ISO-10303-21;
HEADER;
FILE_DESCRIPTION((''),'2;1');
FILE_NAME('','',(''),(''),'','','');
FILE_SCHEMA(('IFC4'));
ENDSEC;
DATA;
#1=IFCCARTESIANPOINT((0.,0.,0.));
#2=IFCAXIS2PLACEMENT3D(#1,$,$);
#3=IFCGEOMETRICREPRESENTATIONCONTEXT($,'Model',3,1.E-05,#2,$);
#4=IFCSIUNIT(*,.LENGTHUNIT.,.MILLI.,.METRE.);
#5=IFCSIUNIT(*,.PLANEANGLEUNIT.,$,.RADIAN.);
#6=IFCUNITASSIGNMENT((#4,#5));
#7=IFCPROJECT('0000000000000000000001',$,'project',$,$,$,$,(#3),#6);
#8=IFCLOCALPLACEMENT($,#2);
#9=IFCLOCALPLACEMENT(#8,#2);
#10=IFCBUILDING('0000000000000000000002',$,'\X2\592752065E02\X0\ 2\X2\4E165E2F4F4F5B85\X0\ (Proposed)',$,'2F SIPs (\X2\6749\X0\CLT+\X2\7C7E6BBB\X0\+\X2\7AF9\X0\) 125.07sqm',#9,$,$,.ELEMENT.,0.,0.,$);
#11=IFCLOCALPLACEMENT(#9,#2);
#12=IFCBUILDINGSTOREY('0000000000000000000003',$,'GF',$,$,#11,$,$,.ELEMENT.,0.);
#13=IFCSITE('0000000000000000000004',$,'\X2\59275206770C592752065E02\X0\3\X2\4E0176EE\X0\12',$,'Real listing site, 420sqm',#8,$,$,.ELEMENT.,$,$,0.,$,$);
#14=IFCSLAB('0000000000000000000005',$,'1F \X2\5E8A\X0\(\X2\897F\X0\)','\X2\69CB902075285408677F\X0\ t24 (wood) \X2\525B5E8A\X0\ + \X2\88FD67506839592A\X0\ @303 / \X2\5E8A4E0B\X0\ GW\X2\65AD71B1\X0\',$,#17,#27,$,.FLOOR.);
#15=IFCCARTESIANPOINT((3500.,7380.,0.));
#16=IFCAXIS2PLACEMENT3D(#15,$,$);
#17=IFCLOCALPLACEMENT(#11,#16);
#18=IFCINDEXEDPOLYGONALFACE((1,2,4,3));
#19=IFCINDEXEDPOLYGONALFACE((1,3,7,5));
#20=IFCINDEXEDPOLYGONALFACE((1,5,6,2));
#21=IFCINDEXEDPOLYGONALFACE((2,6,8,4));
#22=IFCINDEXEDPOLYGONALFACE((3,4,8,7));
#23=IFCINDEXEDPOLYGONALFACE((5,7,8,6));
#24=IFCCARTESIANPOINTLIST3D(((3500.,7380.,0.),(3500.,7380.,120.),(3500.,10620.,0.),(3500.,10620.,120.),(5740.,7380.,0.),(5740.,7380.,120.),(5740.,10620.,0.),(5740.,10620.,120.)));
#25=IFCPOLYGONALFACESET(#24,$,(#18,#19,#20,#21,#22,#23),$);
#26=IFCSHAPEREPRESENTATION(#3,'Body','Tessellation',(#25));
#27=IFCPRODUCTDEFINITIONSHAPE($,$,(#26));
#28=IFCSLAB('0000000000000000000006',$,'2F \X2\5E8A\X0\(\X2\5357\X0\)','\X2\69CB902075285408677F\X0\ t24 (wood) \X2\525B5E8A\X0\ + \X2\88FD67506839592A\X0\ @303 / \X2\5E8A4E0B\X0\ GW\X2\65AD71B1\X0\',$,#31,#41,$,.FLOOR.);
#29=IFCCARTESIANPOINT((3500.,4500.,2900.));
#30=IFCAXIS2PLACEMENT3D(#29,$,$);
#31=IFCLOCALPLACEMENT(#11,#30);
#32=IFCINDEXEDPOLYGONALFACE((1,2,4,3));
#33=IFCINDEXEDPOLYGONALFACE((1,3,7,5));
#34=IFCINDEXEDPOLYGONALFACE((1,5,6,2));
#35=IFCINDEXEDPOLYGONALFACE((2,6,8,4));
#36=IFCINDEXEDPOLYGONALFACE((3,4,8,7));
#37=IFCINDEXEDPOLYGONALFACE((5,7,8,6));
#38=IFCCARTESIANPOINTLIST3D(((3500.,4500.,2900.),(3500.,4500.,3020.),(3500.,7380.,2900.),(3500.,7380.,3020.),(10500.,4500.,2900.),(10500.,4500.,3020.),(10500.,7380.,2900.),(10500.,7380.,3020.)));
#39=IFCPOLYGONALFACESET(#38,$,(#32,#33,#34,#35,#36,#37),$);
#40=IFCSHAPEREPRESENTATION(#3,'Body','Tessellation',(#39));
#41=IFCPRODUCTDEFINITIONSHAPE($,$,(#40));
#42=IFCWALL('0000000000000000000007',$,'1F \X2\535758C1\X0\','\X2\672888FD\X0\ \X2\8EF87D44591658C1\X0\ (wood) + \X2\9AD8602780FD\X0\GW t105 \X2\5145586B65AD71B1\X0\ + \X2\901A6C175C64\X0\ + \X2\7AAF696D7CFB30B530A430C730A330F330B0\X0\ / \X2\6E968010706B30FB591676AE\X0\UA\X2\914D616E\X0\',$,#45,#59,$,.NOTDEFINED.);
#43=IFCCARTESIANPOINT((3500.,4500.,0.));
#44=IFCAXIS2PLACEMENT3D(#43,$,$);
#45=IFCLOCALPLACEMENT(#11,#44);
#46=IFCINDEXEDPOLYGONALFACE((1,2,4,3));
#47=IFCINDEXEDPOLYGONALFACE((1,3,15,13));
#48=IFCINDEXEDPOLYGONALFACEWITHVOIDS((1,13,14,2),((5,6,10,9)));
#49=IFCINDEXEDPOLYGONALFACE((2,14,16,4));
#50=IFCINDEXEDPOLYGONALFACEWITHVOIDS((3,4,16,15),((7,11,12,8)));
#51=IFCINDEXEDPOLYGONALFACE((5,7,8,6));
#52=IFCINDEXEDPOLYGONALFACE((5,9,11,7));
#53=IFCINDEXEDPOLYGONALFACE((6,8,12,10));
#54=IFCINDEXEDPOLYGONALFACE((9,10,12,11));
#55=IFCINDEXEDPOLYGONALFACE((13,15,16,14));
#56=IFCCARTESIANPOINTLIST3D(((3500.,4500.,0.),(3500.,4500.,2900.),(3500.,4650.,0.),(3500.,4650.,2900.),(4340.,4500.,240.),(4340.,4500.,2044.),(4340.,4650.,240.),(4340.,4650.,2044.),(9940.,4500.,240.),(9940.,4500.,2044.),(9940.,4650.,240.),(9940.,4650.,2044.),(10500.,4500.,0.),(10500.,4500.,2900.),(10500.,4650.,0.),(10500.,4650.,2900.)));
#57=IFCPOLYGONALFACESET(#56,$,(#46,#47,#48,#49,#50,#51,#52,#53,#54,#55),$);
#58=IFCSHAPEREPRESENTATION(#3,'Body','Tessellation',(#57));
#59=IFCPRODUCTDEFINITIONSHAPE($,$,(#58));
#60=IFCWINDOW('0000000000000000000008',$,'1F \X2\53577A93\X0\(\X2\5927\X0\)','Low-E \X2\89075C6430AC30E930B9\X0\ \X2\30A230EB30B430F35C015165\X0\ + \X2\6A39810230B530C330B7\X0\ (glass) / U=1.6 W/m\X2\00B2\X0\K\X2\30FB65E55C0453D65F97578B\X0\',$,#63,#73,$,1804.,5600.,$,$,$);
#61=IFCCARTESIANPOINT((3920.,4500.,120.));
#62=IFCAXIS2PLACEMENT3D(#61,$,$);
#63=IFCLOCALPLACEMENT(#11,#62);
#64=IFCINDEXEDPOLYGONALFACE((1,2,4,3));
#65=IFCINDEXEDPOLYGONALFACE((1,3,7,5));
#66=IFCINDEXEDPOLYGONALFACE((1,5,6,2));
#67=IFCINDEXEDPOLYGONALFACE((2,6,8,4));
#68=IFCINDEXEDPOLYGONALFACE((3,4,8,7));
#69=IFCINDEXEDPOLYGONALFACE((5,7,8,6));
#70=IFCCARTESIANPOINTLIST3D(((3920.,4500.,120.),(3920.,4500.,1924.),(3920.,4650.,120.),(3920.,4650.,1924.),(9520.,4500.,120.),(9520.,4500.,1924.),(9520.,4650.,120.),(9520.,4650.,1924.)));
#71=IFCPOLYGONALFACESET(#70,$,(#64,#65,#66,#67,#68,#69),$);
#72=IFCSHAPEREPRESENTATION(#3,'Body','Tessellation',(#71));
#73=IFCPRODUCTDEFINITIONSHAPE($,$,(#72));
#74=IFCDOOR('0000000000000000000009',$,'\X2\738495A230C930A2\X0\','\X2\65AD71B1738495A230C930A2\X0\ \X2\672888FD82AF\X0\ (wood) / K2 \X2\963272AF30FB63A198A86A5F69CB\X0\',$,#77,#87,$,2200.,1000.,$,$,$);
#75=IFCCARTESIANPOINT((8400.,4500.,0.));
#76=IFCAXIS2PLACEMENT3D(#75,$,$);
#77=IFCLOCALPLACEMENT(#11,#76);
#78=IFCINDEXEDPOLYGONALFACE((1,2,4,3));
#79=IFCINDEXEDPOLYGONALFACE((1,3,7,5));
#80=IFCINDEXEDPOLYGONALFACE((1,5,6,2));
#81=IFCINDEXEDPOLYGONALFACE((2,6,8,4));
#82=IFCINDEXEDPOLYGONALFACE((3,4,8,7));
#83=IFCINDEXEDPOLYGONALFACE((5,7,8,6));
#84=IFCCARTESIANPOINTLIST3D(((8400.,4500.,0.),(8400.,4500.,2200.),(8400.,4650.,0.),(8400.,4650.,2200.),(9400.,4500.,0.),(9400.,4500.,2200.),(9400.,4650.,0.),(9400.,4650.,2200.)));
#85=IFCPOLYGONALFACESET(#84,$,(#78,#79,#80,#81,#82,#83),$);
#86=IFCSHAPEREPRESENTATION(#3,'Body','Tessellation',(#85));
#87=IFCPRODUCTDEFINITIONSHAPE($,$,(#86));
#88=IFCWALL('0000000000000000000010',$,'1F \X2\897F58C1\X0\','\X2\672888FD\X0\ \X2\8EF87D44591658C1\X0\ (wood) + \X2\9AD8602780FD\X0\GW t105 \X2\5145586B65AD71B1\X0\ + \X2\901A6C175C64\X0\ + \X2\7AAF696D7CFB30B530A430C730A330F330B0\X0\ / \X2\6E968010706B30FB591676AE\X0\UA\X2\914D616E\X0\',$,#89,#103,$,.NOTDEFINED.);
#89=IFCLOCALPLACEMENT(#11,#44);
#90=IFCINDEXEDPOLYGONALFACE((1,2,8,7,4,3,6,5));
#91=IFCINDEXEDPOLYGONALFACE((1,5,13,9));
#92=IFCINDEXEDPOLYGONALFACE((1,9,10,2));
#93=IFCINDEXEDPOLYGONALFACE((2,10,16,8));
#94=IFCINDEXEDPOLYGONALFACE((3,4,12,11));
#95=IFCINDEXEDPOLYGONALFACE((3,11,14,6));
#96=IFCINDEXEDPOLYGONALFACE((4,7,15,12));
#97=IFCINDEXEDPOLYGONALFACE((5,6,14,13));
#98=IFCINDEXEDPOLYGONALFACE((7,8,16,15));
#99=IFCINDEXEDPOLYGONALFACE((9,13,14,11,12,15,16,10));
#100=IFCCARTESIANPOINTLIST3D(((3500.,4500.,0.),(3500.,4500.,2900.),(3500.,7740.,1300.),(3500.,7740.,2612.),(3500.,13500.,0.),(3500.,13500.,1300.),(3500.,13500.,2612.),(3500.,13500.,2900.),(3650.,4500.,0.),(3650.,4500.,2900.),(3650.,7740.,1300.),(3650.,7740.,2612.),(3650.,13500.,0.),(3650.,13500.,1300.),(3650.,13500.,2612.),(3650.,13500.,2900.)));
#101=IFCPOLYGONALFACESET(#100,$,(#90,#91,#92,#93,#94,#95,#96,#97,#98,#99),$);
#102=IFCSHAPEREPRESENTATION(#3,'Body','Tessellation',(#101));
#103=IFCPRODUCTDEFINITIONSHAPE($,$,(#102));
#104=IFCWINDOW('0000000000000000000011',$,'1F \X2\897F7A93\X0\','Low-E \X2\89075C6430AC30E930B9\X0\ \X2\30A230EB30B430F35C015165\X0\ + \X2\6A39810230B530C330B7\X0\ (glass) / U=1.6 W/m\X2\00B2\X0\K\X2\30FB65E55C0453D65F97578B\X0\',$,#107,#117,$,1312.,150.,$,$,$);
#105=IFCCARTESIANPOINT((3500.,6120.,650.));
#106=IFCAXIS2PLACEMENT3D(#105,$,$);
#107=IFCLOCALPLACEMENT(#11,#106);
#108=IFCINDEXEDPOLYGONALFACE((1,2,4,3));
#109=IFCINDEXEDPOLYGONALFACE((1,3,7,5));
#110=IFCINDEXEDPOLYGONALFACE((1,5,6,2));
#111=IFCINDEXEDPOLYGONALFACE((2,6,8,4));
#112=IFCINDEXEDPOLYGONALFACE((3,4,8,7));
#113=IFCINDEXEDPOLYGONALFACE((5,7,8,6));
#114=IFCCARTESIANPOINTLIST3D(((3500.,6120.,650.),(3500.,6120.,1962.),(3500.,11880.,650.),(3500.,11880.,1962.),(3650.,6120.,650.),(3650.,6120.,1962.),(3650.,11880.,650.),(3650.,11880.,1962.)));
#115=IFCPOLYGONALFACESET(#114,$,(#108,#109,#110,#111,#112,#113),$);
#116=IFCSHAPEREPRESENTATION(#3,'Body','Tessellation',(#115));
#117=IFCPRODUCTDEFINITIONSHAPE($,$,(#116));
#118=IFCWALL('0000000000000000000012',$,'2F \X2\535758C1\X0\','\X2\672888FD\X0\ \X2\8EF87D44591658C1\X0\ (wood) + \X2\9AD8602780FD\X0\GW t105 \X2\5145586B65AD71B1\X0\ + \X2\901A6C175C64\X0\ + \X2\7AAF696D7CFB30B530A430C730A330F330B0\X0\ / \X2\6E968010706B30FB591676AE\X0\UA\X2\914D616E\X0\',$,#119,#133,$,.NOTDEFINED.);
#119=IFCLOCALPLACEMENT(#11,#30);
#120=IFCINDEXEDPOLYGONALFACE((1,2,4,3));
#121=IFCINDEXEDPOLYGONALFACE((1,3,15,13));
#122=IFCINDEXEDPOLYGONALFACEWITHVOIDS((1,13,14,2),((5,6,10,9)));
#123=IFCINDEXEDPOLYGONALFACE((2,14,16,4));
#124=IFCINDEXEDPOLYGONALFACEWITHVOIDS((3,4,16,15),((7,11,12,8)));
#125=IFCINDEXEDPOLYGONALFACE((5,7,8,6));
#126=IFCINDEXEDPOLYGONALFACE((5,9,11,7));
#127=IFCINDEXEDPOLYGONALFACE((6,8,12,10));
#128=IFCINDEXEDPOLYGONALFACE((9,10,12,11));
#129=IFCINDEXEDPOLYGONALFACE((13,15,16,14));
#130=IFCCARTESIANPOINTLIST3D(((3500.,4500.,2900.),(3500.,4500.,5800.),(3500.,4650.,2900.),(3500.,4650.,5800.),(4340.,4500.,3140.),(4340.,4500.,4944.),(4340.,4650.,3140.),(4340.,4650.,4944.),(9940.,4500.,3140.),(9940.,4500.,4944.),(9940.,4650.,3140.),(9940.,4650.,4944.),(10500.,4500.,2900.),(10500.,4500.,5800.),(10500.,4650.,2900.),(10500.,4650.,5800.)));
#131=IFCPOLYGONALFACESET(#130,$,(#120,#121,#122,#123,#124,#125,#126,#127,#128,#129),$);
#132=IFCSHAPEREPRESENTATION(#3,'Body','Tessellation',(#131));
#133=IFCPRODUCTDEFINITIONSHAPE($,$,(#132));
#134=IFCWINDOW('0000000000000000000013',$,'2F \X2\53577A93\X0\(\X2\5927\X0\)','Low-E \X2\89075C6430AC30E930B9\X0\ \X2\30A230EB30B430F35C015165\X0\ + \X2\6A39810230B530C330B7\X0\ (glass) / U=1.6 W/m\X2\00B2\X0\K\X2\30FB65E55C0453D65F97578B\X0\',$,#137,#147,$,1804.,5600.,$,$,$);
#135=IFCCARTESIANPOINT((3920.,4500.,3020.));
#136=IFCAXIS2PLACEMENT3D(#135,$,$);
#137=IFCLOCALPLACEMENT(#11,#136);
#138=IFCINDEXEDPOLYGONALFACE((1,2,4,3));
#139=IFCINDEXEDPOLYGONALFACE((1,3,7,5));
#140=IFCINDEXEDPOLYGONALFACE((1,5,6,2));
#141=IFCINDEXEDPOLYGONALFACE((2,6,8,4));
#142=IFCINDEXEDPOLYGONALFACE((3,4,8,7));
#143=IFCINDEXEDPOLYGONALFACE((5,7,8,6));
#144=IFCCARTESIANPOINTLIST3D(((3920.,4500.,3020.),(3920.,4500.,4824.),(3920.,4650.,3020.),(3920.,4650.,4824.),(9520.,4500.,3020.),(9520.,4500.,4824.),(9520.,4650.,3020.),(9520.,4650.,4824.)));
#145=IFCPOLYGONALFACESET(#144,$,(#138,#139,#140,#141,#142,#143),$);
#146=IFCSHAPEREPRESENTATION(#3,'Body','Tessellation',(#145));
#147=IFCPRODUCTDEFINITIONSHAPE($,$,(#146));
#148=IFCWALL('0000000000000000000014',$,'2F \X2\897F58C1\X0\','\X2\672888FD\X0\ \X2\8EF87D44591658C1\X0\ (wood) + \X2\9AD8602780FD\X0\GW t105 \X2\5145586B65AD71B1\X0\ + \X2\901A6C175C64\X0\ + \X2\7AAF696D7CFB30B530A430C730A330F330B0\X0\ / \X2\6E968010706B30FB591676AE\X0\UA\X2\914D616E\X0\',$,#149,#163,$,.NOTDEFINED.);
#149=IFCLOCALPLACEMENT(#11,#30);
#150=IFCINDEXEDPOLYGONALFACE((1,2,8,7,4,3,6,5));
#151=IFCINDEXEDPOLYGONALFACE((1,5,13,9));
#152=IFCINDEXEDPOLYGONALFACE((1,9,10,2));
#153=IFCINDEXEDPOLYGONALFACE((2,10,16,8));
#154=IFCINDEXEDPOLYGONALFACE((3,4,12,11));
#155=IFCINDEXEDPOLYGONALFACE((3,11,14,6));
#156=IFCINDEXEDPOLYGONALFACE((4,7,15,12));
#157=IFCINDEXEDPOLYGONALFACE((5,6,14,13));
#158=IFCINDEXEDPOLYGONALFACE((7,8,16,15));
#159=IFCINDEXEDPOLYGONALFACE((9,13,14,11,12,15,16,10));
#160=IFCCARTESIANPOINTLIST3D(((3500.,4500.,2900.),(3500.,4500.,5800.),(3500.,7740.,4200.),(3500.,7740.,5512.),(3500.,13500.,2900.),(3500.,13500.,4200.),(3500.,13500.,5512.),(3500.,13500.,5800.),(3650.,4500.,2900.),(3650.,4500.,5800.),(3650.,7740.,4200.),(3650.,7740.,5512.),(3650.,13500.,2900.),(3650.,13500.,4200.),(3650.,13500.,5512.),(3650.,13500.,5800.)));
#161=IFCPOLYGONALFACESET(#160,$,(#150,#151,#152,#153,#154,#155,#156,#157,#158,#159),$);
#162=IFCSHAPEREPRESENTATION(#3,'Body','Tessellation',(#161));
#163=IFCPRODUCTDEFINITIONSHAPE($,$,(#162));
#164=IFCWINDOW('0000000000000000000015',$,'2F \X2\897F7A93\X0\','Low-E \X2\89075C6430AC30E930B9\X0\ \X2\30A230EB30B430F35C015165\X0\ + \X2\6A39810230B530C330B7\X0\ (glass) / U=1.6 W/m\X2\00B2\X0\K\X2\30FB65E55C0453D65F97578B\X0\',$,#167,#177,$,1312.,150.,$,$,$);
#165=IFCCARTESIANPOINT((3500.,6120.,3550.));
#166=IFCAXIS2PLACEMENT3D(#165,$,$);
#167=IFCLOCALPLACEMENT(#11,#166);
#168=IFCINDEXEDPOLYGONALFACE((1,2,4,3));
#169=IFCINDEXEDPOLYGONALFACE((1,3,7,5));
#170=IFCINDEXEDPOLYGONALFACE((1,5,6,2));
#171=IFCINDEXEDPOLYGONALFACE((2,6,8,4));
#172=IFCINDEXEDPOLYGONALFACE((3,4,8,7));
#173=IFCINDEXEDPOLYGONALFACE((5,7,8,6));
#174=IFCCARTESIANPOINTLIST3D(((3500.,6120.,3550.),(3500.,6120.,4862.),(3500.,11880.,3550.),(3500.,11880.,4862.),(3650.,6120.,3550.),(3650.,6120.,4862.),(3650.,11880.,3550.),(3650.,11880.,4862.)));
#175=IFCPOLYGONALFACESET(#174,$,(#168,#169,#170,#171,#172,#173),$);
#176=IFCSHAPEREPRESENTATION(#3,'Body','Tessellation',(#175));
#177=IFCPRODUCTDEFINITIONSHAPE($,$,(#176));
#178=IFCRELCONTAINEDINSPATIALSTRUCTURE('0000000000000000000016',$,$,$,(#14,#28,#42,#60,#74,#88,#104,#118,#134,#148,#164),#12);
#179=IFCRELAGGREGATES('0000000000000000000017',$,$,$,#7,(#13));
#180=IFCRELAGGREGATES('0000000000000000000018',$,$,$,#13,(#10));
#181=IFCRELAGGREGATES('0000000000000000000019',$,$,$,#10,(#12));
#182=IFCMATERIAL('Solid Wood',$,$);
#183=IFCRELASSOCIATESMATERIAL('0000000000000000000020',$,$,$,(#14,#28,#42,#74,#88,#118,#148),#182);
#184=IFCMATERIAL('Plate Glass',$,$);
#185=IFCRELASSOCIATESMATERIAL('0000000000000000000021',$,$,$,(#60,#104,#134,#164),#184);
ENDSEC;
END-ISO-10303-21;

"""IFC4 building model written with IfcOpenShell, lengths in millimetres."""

from ifc_helpers import new_model, si_unit, frame, frame_2d, origin, place, context, project, spatial, rectangle, extrude, material, element, fill, save


model = new_model("IFC4")

# Units and contexts
model_context = context("Model", 3, precision=1e-05, world=origin())
ifc_project = project(units=[si_unit("LENGTHUNIT", "METRE", prefix="MILLI"), si_unit("PLANEANGLEUNIT", "RADIAN")], contexts=[model_context])

# Site, building, storey
site_placement = place(None, origin())
site = spatial("IfcSite", under=ifc_project, at=site_placement, Name="大分県大分市3丁目12", ObjectType="Real listing site, 420sqm", CompositionType="ELEMENT", RefElevation=0.0)
building_placement = place(site_placement, origin())
building = spatial("IfcBuilding", under=site, at=building_placement, Name="大分市 2世帯住宅 (Proposed)", ObjectType="2F SIPs (杉CLT+籾殻+竹) 125.07sqm", CompositionType="ELEMENT", ElevationOfRefHeight=0.0, ElevationOfTerrain=0.0)
storey_placement = place(building_placement, origin())
storey = spatial("IfcBuildingStorey", under=building, at=storey_placement, Name="GF", CompositionType="ELEMENT", Elevation=0.0)

# Slabs
ifc_material_1 = material(Name="Solid Wood")
slab_1_placement = place(storey_placement, frame((3500.0, 7380.0, 0.0)))
element("IfcSlab", 1, at=slab_1_placement, inside=storey, material=ifc_material_1, Name="1F 床(西)", Description="構造用合板 t24 (wood) 剛床 + 製材根太 @303 / 床下 GW断熱", PredefinedType="FLOOR", context=model_context, shape_type="SweptSolid", body=[
    extrude(rectangle(XDim=2240.0, YDim=3240.0, at=frame_2d((1120.0, 1620.0))), frame((3500.0, 7380.0, 0.0)), (0.0, 0.0, 1.0), 120.0),
])
slab_2_placement = place(storey_placement, frame((3500.0, 4500.0, 2900.0)))
element("IfcSlab", 2, at=slab_2_placement, inside=storey, material=ifc_material_1, Name="2F 床(南)", Description="構造用合板 t24 (wood) 剛床 + 製材根太 @303 / 床下 GW断熱", PredefinedType="FLOOR", context=model_context, shape_type="SweptSolid", body=[
    extrude(rectangle(XDim=7000.0, YDim=2880.0, at=frame_2d((3500.0, 1440.0))), frame((3500.0, 4500.0, 2900.0)), (0.0, 0.0, 1.0), 120.0),
])

# Wall, openings, window, door
wall_1_placement = place(storey_placement, frame((3500.0, 4500.0, 0.0)))
wall_1 = element("IfcWall", 3, at=wall_1_placement, inside=storey, material=ifc_material_1, Name="1F 南壁", Description="木製 軸組外壁 (wood) + 高性能GW t105 充填断熱 + 通気層 + 窯業系サイディング / 準耐火・外皮UA配慮", PredefinedType="NOTDEFINED", context=model_context, shape_type="SweptSolid", body=[
    extrude(rectangle(XDim=7000.0, YDim=150.0, at=frame_2d((3500.0, 75.0))), frame((3500.0, 4500.0, 0.0)), (0.0, 0.0, 1.0), 2900.0),
])
opening_1_placement = place(storey_placement, frame((3920.0, 4500.0, 120.0)))
opening_1 = element("IfcOpeningElement", 4, at=opening_1_placement, cuts=wall_1, PredefinedType="NOTDEFINED", context=model_context, shape_type="SweptSolid", body=[
    extrude(rectangle(XDim=5600.0, YDim=150.0, at=frame_2d((2800.0, 75.0))), frame((3920.0, 4500.0, 120.0)), (0.0, 0.0, 1.0), 1804.0),
])
opening_2_placement = place(storey_placement, frame((8400.0, 4500.0, 0.0)))
opening_2 = element("IfcOpeningElement", 5, at=opening_2_placement, cuts=wall_1, PredefinedType="NOTDEFINED", context=model_context, shape_type="SweptSolid", body=[
    extrude(rectangle(XDim=1000.0, YDim=150.0, at=frame_2d((500.0, 75.0))), frame((8400.0, 4500.0, 0.0)), (0.0, 0.0, 1.0), 2200.0),
])
ifc_material_2 = material(Name="Plate Glass")
window_1_placement = place(storey_placement, frame((3920.0, 4500.0, 120.0)))
window_1 = element("IfcWindow", 6, at=window_1_placement, inside=storey, material=ifc_material_2, Name="1F 南窓(大)", Description="Low-E 複層ガラス アルゴン封入 + 樹脂サッシ (glass) / U=1.6 W/m²K・日射取得型", OverallHeight=1804.0, OverallWidth=5600.0, context=model_context, shape_type="SweptSolid", body=[
    extrude(rectangle(XDim=5600.0, YDim=150.0, at=frame_2d((2800.0, 75.0))), frame((3920.0, 4500.0, 120.0)), (0.0, 0.0, 1.0), 1804.0),
])
fill(opening_1, window_1)
door_placement = place(storey_placement, frame((8400.0, 4500.0, 0.0)))
door = element("IfcDoor", 7, at=door_placement, inside=storey, material=ifc_material_1, Name="玄関ドア", Description="断熱玄関ドア 木製芯 (wood) / K2 防犯・採風機構", OverallHeight=2200.0, OverallWidth=1000.0, context=model_context, shape_type="SweptSolid", body=[
    extrude(rectangle(XDim=1000.0, YDim=150.0, at=frame_2d((500.0, 75.0))), frame((8400.0, 4500.0, 0.0)), (0.0, 0.0, 1.0), 2200.0),
])
fill(opening_2, door)

# Walls, openings, windows
wall_2_placement = place(storey_placement, frame((3500.0, 4500.0, 0.0)))
wall_2 = element("IfcWall", 8, at=wall_2_placement, inside=storey, material=ifc_material_1, Name="1F 西壁", Description="木製 軸組外壁 (wood) + 高性能GW t105 充填断熱 + 通気層 + 窯業系サイディング / 準耐火・外皮UA配慮", PredefinedType="NOTDEFINED", context=model_context, shape_type="SweptSolid", body=[
    extrude(rectangle(XDim=150.0, YDim=9000.0, at=frame_2d((75.0, 4500.0))), frame((3500.0, 4500.0, 0.0)), (0.0, 0.0, 1.0), 2900.0),
])
opening_3_placement = place(storey_placement, frame((3500.0, 6120.0, 650.0)))
opening_3 = element("IfcOpeningElement", 9, at=opening_3_placement, cuts=wall_2, PredefinedType="NOTDEFINED", context=model_context, shape_type="SweptSolid", body=[
    extrude(rectangle(XDim=150.0, YDim=5760.0, at=frame_2d((75.0, 2880.0))), frame((3500.0, 6120.0, 650.0)), (0.0, 0.0, 1.0), 1312.0),
])
window_2_placement = place(storey_placement, frame((3500.0, 6120.0, 650.0)))
window_2 = element("IfcWindow", 10, at=window_2_placement, inside=storey, material=ifc_material_2, Name="1F 西窓", Description="Low-E 複層ガラス アルゴン封入 + 樹脂サッシ (glass) / U=1.6 W/m²K・日射取得型", OverallHeight=1312.0, OverallWidth=150.0, context=model_context, shape_type="SweptSolid", body=[
    extrude(rectangle(XDim=150.0, YDim=5760.0, at=frame_2d((75.0, 2880.0))), frame((3500.0, 6120.0, 650.0)), (0.0, 0.0, 1.0), 1312.0),
])
fill(opening_3, window_2)
wall_3_placement = place(storey_placement, frame((3500.0, 4500.0, 2900.0)))
wall_3 = element("IfcWall", 11, at=wall_3_placement, inside=storey, material=ifc_material_1, Name="2F 南壁", Description="木製 軸組外壁 (wood) + 高性能GW t105 充填断熱 + 通気層 + 窯業系サイディング / 準耐火・外皮UA配慮", PredefinedType="NOTDEFINED", context=model_context, shape_type="SweptSolid", body=[
    extrude(rectangle(XDim=7000.0, YDim=150.0, at=frame_2d((3500.0, 75.0))), frame((3500.0, 4500.0, 2900.0)), (0.0, 0.0, 1.0), 2900.0),
])
opening_4_placement = place(storey_placement, frame((3920.0, 4500.0, 3020.0)))
opening_4 = element("IfcOpeningElement", 12, at=opening_4_placement, cuts=wall_3, PredefinedType="NOTDEFINED", context=model_context, shape_type="SweptSolid", body=[
    extrude(rectangle(XDim=5600.0, YDim=150.0, at=frame_2d((2800.0, 75.0))), frame((3920.0, 4500.0, 3020.0)), (0.0, 0.0, 1.0), 1804.0),
])
window_3_placement = place(storey_placement, frame((3920.0, 4500.0, 3020.0)))
window_3 = element("IfcWindow", 13, at=window_3_placement, inside=storey, material=ifc_material_2, Name="2F 南窓(大)", Description="Low-E 複層ガラス アルゴン封入 + 樹脂サッシ (glass) / U=1.6 W/m²K・日射取得型", OverallHeight=1804.0, OverallWidth=5600.0, context=model_context, shape_type="SweptSolid", body=[
    extrude(rectangle(XDim=5600.0, YDim=150.0, at=frame_2d((2800.0, 75.0))), frame((3920.0, 4500.0, 3020.0)), (0.0, 0.0, 1.0), 1804.0),
])
fill(opening_4, window_3)
wall_4_placement = place(storey_placement, frame((3500.0, 4500.0, 2900.0)))
wall_4 = element("IfcWall", 14, at=wall_4_placement, inside=storey, material=ifc_material_1, Name="2F 西壁", Description="木製 軸組外壁 (wood) + 高性能GW t105 充填断熱 + 通気層 + 窯業系サイディング / 準耐火・外皮UA配慮", PredefinedType="NOTDEFINED", context=model_context, shape_type="SweptSolid", body=[
    extrude(rectangle(XDim=150.0, YDim=9000.0, at=frame_2d((75.0, 4500.0))), frame((3500.0, 4500.0, 2900.0)), (0.0, 0.0, 1.0), 2900.0),
])
opening_5_placement = place(storey_placement, frame((3500.0, 6120.0, 3550.0)))
opening_5 = element("IfcOpeningElement", 15, at=opening_5_placement, cuts=wall_4, PredefinedType="NOTDEFINED", context=model_context, shape_type="SweptSolid", body=[
    extrude(rectangle(XDim=150.0, YDim=5760.0, at=frame_2d((75.0, 2880.0))), frame((3500.0, 6120.0, 3550.0)), (0.0, 0.0, 1.0), 1312.0),
])
window_4_placement = place(storey_placement, frame((3500.0, 6120.0, 3550.0)))
window_4 = element("IfcWindow", 16, at=window_4_placement, inside=storey, material=ifc_material_2, Name="2F 西窓", Description="Low-E 複層ガラス アルゴン封入 + 樹脂サッシ (glass) / U=1.6 W/m²K・日射取得型", OverallHeight=1312.0, OverallWidth=150.0, context=model_context, shape_type="SweptSolid", body=[
    extrude(rectangle(XDim=150.0, YDim=5760.0, at=frame_2d((75.0, 2880.0))), frame((3500.0, 6120.0, 3550.0)), (0.0, 0.0, 1.0), 1312.0),
])
fill(opening_5, window_4)

save(model, "model.ifc")
